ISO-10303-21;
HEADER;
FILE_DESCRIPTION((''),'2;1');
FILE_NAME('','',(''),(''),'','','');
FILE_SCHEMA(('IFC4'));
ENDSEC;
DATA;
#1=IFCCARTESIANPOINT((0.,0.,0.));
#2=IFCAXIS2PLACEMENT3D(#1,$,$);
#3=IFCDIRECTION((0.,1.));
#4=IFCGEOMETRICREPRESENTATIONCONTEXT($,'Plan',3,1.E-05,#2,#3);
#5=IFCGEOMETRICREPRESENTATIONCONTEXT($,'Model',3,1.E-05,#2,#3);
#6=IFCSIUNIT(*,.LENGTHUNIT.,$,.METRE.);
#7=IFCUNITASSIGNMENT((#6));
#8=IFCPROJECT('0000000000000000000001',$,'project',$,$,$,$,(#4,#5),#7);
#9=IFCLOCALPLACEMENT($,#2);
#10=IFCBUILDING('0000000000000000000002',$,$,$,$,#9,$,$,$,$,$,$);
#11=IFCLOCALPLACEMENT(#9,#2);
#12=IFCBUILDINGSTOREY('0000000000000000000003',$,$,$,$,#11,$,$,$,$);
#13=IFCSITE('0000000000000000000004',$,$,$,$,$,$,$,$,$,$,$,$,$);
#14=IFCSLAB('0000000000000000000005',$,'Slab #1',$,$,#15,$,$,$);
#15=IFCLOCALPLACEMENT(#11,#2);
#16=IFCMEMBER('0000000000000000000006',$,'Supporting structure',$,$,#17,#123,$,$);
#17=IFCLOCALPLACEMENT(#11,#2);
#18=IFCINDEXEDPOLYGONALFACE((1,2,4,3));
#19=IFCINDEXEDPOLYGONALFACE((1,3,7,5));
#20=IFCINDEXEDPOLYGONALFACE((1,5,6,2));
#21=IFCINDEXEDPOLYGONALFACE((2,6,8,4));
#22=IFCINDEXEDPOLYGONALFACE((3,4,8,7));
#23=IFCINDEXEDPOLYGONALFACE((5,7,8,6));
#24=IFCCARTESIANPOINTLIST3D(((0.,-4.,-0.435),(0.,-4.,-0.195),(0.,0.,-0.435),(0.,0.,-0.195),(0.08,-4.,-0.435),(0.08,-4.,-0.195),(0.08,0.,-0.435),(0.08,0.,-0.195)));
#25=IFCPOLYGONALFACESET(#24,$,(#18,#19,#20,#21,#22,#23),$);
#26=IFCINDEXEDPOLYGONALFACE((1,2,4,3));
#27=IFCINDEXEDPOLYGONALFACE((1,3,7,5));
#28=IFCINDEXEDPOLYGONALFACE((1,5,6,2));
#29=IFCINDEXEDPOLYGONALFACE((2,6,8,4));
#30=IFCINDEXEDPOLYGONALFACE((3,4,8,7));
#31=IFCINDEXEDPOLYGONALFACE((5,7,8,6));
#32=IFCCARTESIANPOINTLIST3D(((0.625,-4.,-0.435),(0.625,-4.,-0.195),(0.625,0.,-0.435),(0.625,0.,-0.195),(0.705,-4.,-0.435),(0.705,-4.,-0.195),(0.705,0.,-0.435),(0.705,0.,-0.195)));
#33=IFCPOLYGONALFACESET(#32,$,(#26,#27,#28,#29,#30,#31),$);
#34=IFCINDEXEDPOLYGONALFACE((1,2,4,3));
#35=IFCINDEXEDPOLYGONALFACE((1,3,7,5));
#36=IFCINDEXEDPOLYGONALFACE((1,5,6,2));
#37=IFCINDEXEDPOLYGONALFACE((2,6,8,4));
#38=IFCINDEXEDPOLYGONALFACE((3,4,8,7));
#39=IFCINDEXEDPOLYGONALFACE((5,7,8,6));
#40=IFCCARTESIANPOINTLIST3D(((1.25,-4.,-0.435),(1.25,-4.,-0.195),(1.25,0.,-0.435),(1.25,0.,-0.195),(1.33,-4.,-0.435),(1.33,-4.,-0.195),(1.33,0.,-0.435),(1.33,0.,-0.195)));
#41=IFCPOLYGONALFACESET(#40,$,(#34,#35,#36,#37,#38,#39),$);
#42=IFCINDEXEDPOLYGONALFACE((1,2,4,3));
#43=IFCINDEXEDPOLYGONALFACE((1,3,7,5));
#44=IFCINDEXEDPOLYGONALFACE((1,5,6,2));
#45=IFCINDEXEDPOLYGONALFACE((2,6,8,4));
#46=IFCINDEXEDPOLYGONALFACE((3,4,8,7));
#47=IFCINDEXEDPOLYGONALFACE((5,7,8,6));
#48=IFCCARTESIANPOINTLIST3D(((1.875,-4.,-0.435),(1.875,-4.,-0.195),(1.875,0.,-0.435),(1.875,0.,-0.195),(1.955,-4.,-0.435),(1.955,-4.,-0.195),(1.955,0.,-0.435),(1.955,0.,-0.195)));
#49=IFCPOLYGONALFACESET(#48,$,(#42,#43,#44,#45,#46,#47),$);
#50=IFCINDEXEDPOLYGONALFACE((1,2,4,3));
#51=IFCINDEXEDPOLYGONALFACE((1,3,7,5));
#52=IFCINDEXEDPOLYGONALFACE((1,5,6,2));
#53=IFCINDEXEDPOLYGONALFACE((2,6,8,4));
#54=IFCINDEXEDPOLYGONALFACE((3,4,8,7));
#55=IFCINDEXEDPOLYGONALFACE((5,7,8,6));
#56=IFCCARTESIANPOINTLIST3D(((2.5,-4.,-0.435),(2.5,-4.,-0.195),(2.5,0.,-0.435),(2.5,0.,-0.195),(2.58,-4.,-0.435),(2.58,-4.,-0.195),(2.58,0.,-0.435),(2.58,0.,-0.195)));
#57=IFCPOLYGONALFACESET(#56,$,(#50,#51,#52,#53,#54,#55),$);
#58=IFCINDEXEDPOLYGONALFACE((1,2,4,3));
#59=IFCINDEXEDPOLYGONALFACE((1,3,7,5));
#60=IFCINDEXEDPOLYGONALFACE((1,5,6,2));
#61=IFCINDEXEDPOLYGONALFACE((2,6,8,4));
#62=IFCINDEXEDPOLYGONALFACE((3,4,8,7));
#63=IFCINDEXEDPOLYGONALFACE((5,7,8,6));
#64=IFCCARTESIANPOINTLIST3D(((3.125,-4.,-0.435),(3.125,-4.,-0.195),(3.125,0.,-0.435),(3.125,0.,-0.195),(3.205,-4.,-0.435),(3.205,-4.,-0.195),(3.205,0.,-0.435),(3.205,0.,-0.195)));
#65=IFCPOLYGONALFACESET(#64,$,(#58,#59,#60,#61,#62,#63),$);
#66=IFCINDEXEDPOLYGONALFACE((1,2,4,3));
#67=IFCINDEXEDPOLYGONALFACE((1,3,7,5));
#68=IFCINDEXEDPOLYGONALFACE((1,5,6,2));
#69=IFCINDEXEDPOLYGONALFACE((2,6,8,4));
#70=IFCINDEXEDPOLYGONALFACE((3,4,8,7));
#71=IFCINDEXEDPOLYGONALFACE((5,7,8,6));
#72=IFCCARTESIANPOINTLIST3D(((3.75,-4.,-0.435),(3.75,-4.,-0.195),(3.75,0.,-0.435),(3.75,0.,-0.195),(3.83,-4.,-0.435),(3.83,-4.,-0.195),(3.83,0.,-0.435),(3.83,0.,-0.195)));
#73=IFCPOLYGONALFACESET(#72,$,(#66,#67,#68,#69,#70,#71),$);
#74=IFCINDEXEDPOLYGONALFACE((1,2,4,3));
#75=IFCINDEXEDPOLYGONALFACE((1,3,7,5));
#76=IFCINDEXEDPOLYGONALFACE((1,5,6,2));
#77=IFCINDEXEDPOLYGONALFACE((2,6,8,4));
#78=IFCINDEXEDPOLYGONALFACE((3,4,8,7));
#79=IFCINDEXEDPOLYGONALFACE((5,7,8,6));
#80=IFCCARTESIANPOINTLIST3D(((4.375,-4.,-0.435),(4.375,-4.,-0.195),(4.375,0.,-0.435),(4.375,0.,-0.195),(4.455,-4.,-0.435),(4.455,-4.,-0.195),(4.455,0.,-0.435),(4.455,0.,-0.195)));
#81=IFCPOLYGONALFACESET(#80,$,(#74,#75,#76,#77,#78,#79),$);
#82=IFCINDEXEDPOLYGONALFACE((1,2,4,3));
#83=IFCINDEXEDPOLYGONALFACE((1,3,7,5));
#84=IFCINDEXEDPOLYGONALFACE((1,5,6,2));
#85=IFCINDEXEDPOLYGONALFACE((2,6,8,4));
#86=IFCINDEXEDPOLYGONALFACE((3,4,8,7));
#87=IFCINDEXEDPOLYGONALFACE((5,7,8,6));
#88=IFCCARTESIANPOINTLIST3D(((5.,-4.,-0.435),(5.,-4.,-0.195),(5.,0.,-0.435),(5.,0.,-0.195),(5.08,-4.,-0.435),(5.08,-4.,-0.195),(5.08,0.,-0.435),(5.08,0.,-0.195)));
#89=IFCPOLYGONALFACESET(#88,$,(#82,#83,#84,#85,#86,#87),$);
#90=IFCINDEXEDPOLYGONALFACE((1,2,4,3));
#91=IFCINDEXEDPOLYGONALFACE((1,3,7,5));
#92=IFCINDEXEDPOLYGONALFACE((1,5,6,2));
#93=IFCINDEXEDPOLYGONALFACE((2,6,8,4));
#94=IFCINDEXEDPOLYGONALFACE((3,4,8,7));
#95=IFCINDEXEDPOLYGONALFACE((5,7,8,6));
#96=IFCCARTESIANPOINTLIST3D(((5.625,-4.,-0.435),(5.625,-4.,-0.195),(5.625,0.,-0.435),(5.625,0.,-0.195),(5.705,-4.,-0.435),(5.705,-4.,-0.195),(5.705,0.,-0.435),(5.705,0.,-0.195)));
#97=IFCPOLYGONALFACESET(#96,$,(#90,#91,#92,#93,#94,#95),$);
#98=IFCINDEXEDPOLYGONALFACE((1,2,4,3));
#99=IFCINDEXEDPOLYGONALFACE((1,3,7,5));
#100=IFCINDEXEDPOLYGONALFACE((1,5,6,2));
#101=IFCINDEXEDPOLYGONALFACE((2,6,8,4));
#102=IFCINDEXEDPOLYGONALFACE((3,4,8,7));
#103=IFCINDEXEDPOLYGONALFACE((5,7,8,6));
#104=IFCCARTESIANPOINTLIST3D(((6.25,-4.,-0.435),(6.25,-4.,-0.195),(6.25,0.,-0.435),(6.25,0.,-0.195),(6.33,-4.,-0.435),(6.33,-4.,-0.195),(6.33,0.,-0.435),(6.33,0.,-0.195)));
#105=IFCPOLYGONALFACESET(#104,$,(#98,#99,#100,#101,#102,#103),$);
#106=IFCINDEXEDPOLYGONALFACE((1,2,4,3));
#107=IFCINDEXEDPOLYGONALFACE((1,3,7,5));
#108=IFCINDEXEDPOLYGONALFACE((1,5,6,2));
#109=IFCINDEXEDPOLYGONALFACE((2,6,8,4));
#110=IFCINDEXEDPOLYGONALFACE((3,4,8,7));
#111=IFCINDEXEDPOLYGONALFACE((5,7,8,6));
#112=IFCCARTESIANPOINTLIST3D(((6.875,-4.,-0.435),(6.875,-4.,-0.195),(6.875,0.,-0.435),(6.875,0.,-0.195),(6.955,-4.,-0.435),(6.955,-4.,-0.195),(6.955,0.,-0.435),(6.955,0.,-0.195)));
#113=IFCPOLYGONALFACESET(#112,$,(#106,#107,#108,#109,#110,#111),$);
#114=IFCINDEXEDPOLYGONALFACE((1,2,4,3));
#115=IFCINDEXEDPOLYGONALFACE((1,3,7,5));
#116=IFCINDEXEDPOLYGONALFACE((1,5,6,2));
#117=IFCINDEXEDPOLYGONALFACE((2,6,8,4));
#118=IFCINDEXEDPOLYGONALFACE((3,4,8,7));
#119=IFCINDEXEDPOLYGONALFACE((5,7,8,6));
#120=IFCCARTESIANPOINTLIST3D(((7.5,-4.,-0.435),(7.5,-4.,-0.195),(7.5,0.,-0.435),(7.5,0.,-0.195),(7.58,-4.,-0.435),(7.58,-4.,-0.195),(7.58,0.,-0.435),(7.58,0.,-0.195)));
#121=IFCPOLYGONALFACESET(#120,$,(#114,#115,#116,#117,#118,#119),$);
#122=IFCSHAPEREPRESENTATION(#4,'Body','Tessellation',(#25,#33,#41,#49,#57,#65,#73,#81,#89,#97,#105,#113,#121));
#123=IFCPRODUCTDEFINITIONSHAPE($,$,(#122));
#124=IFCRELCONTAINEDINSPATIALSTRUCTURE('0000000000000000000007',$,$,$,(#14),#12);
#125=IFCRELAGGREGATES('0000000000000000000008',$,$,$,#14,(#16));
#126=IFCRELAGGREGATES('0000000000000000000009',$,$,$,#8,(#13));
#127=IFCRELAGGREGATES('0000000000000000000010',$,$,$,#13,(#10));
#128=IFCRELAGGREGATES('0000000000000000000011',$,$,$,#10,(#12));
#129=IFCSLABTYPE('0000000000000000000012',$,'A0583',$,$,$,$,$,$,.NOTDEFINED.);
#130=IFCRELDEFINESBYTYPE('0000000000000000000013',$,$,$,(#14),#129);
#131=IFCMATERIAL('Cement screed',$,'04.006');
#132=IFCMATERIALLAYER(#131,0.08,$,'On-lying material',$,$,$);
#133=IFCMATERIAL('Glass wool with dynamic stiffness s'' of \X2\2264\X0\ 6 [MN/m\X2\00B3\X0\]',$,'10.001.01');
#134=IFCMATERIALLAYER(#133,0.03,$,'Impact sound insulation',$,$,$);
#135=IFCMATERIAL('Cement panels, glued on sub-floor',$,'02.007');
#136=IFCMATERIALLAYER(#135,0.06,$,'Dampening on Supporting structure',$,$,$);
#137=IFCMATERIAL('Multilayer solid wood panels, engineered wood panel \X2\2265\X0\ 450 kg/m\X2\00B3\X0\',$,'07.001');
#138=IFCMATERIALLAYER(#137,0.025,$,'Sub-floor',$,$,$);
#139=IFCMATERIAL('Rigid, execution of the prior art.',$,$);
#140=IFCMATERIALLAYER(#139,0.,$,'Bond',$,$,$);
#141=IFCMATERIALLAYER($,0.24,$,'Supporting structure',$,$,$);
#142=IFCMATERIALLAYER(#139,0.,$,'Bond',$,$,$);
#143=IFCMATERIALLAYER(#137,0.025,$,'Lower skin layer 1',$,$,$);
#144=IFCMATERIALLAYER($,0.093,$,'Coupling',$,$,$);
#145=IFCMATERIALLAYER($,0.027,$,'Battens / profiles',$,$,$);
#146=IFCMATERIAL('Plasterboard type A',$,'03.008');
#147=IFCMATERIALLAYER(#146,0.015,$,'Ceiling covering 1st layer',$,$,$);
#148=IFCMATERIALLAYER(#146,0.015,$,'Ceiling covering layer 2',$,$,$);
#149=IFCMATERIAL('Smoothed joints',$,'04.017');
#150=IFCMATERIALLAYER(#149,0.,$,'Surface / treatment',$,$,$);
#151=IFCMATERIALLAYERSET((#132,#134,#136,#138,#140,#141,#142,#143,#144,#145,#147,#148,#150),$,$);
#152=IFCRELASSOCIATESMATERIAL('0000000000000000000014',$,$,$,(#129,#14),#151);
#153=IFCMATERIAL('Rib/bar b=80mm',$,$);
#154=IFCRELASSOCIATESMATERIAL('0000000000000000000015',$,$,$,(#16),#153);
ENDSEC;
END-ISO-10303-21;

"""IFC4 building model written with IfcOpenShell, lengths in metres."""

from ifc_helpers import new_model, si_unit, direction, frame, frame_2d, origin, place, context, project, spatial, rectangle, extrude, material, layer, layer_set, type_object, element, aggregate, save


model = new_model("IFC4")

# Units and contexts
plan_context = context("Plan", 3, precision=1e-05, world=origin(), true_north=direction((0.0, 1.0)))
model_context = context("Model", 3, precision=1e-05, world=origin(), true_north=direction((0.0, 1.0)))
ifc_project = project(units=[si_unit("LENGTHUNIT", "METRE")], contexts=[plan_context, model_context])

# Site, building, storey
site = spatial("IfcSite", under=ifc_project)
building_placement = place(None, origin())
building = spatial("IfcBuilding", under=site, at=building_placement)
storey_placement = place(building_placement, origin())
storey = spatial("IfcBuildingStorey", under=building, at=storey_placement)

# Slab, member
ifc_material_1 = material(Name="Cement screed", Category="04.006")
ifc_layer_1 = layer(ifc_material_1, 0.08, Name="On-lying material")
ifc_material_2 = material(Name="Glass wool with dynamic stiffness s' of ≤ 6 [MN/m³]", Category="10.001.01")
ifc_layer_2 = layer(ifc_material_2, 0.03, Name="Impact sound insulation")
ifc_material_3 = material(Name="Cement panels, glued on sub-floor", Category="02.007")
ifc_layer_3 = layer(ifc_material_3, 0.06, Name="Dampening on Supporting structure")
ifc_material_4 = material(Name="Multilayer solid wood panels, engineered wood panel ≥ 450 kg/m³", Category="07.001")
ifc_layer_4 = layer(ifc_material_4, 0.025, Name="Sub-floor")
ifc_material_5 = material(Name="Rigid, execution of the prior art.")
ifc_layer_5 = layer(ifc_material_5, 0.0, Name="Bond")
ifc_layer_6 = layer(None, 0.24, Name="Supporting structure")
ifc_layer_7 = layer(ifc_material_5, 0.0, Name="Bond")
ifc_layer_8 = layer(ifc_material_4, 0.025, Name="Lower skin layer 1")
ifc_layer_9 = layer(None, 0.093, Name="Coupling")
ifc_layer_10 = layer(None, 0.027, Name="Battens / profiles")
ifc_material_6 = material(Name="Plasterboard type A", Category="03.008")
ifc_layer_11 = layer(ifc_material_6, 0.015, Name="Ceiling covering 1st layer")
ifc_layer_12 = layer(ifc_material_6, 0.015, Name="Ceiling covering layer 2")
ifc_material_7 = material(Name="Smoothed joints", Category="04.017")
ifc_layer_13 = layer(ifc_material_7, 0.0, Name="Surface / treatment")
ifc_layer_set = layer_set([ifc_layer_1, ifc_layer_2, ifc_layer_3, ifc_layer_4, ifc_layer_5, ifc_layer_6, ifc_layer_7, ifc_layer_8, ifc_layer_9, ifc_layer_10, ifc_layer_11, ifc_layer_12, ifc_layer_13])
slab_type = type_object("IfcSlabType", Name="A0583", PredefinedType="NOTDEFINED", material=ifc_layer_set)
slab_placement = place(None, frame((0.0, 0.0, 0.0), z_axis=(0.0, 0.0, -1.0), x_axis=(1.0, 0.0, 0.0)))
slab = element("IfcSlab", 1, at=slab_placement, inside=storey, type_object=slab_type, material=ifc_layer_set, Name="Slab #1")
ifc_material_8 = material(Name="Rib/bar b=80mm")
member_1_placement = place(slab_placement, origin())
member_1 = element("IfcMember", 2, at=member_1_placement, material=ifc_material_8, Name="Supporting structure", context=plan_context, shape_type="SweptSolid", body=[
    extrude(rectangle(XDim=0.08, YDim=0.24, at=frame_2d((0.04, 0.12), x_axis=(1.0, 0.0))), frame((0.0, 4.0, 0.195), z_axis=(0.0, -1.0, 0.0), x_axis=(1.0, 0.0, 0.0)), (0.0, 0.0, 1.0), 4.0),
    extrude(rectangle(XDim=0.08, YDim=0.24, at=frame_2d((0.04, 0.12), x_axis=(1.0, 0.0))), frame((0.625, 4.0, 0.195), z_axis=(0.0, -1.0, 0.0), x_axis=(1.0, 0.0, 0.0)), (0.0, 0.0, 1.0), 4.0),
    extrude(rectangle(XDim=0.08, YDim=0.24, at=frame_2d((0.04, 0.12), x_axis=(1.0, 0.0))), frame((1.25, 4.0, 0.195), z_axis=(0.0, -1.0, 0.0), x_axis=(1.0, 0.0, 0.0)), (0.0, 0.0, 1.0), 4.0),
    extrude(rectangle(XDim=0.08, YDim=0.24, at=frame_2d((0.04, 0.12), x_axis=(1.0, 0.0))), frame((1.875, 4.0, 0.195), z_axis=(0.0, -1.0, 0.0), x_axis=(1.0, 0.0, 0.0)), (0.0, 0.0, 1.0), 4.0),
    extrude(rectangle(XDim=0.08, YDim=0.24, at=frame_2d((0.04, 0.12), x_axis=(1.0, 0.0))), frame((2.5, 4.0, 0.195), z_axis=(0.0, -1.0, 0.0), x_axis=(1.0, 0.0, 0.0)), (0.0, 0.0, 1.0), 4.0),
    extrude(rectangle(XDim=0.08, YDim=0.24, at=frame_2d((0.04, 0.12), x_axis=(1.0, 0.0))), frame((3.125, 4.0, 0.195), z_axis=(0.0, -1.0, 0.0), x_axis=(1.0, 0.0, 0.0)), (0.0, 0.0, 1.0), 4.0),
    extrude(rectangle(XDim=0.08, YDim=0.24, at=frame_2d((0.04, 0.12), x_axis=(1.0, 0.0))), frame((3.75, 4.0, 0.195), z_axis=(0.0, -1.0, 0.0), x_axis=(1.0, 0.0, 0.0)), (0.0, 0.0, 1.0), 4.0),
    extrude(rectangle(XDim=0.08, YDim=0.24, at=frame_2d((0.04, 0.12), x_axis=(1.0, 0.0))), frame((4.375, 4.0, 0.195), z_axis=(0.0, -1.0, 0.0), x_axis=(1.0, 0.0, 0.0)), (0.0, 0.0, 1.0), 4.0),
    extrude(rectangle(XDim=0.08, YDim=0.24, at=frame_2d((0.04, 0.12), x_axis=(1.0, 0.0))), frame((5.0, 4.0, 0.195), z_axis=(0.0, -1.0, 0.0), x_axis=(1.0, 0.0, 0.0)), (0.0, 0.0, 1.0), 4.0),
    extrude(rectangle(XDim=0.08, YDim=0.24, at=frame_2d((0.04, 0.12), x_axis=(1.0, 0.0))), frame((5.625, 4.0, 0.195), z_axis=(0.0, -1.0, 0.0), x_axis=(1.0, 0.0, 0.0)), (0.0, 0.0, 1.0), 4.0),
    extrude(rectangle(XDim=0.08, YDim=0.24, at=frame_2d((0.04, 0.12), x_axis=(1.0, 0.0))), frame((6.25, 4.0, 0.195), z_axis=(0.0, -1.0, 0.0), x_axis=(1.0, 0.0, 0.0)), (0.0, 0.0, 1.0), 4.0),
    extrude(rectangle(XDim=0.08, YDim=0.24, at=frame_2d((0.04, 0.12), x_axis=(1.0, 0.0))), frame((6.875, 4.0, 0.195), z_axis=(0.0, -1.0, 0.0), x_axis=(1.0, 0.0, 0.0)), (0.0, 0.0, 1.0), 4.0),
    extrude(rectangle(XDim=0.08, YDim=0.24, at=frame_2d((0.04, 0.12), x_axis=(1.0, 0.0))), frame((7.5, 4.0, 0.195), z_axis=(0.0, -1.0, 0.0), x_axis=(1.0, 0.0, 0.0)), (0.0, 0.0, 1.0), 4.0),
])
aggregate(slab, [member_1])

save(model, "model.ifc")
